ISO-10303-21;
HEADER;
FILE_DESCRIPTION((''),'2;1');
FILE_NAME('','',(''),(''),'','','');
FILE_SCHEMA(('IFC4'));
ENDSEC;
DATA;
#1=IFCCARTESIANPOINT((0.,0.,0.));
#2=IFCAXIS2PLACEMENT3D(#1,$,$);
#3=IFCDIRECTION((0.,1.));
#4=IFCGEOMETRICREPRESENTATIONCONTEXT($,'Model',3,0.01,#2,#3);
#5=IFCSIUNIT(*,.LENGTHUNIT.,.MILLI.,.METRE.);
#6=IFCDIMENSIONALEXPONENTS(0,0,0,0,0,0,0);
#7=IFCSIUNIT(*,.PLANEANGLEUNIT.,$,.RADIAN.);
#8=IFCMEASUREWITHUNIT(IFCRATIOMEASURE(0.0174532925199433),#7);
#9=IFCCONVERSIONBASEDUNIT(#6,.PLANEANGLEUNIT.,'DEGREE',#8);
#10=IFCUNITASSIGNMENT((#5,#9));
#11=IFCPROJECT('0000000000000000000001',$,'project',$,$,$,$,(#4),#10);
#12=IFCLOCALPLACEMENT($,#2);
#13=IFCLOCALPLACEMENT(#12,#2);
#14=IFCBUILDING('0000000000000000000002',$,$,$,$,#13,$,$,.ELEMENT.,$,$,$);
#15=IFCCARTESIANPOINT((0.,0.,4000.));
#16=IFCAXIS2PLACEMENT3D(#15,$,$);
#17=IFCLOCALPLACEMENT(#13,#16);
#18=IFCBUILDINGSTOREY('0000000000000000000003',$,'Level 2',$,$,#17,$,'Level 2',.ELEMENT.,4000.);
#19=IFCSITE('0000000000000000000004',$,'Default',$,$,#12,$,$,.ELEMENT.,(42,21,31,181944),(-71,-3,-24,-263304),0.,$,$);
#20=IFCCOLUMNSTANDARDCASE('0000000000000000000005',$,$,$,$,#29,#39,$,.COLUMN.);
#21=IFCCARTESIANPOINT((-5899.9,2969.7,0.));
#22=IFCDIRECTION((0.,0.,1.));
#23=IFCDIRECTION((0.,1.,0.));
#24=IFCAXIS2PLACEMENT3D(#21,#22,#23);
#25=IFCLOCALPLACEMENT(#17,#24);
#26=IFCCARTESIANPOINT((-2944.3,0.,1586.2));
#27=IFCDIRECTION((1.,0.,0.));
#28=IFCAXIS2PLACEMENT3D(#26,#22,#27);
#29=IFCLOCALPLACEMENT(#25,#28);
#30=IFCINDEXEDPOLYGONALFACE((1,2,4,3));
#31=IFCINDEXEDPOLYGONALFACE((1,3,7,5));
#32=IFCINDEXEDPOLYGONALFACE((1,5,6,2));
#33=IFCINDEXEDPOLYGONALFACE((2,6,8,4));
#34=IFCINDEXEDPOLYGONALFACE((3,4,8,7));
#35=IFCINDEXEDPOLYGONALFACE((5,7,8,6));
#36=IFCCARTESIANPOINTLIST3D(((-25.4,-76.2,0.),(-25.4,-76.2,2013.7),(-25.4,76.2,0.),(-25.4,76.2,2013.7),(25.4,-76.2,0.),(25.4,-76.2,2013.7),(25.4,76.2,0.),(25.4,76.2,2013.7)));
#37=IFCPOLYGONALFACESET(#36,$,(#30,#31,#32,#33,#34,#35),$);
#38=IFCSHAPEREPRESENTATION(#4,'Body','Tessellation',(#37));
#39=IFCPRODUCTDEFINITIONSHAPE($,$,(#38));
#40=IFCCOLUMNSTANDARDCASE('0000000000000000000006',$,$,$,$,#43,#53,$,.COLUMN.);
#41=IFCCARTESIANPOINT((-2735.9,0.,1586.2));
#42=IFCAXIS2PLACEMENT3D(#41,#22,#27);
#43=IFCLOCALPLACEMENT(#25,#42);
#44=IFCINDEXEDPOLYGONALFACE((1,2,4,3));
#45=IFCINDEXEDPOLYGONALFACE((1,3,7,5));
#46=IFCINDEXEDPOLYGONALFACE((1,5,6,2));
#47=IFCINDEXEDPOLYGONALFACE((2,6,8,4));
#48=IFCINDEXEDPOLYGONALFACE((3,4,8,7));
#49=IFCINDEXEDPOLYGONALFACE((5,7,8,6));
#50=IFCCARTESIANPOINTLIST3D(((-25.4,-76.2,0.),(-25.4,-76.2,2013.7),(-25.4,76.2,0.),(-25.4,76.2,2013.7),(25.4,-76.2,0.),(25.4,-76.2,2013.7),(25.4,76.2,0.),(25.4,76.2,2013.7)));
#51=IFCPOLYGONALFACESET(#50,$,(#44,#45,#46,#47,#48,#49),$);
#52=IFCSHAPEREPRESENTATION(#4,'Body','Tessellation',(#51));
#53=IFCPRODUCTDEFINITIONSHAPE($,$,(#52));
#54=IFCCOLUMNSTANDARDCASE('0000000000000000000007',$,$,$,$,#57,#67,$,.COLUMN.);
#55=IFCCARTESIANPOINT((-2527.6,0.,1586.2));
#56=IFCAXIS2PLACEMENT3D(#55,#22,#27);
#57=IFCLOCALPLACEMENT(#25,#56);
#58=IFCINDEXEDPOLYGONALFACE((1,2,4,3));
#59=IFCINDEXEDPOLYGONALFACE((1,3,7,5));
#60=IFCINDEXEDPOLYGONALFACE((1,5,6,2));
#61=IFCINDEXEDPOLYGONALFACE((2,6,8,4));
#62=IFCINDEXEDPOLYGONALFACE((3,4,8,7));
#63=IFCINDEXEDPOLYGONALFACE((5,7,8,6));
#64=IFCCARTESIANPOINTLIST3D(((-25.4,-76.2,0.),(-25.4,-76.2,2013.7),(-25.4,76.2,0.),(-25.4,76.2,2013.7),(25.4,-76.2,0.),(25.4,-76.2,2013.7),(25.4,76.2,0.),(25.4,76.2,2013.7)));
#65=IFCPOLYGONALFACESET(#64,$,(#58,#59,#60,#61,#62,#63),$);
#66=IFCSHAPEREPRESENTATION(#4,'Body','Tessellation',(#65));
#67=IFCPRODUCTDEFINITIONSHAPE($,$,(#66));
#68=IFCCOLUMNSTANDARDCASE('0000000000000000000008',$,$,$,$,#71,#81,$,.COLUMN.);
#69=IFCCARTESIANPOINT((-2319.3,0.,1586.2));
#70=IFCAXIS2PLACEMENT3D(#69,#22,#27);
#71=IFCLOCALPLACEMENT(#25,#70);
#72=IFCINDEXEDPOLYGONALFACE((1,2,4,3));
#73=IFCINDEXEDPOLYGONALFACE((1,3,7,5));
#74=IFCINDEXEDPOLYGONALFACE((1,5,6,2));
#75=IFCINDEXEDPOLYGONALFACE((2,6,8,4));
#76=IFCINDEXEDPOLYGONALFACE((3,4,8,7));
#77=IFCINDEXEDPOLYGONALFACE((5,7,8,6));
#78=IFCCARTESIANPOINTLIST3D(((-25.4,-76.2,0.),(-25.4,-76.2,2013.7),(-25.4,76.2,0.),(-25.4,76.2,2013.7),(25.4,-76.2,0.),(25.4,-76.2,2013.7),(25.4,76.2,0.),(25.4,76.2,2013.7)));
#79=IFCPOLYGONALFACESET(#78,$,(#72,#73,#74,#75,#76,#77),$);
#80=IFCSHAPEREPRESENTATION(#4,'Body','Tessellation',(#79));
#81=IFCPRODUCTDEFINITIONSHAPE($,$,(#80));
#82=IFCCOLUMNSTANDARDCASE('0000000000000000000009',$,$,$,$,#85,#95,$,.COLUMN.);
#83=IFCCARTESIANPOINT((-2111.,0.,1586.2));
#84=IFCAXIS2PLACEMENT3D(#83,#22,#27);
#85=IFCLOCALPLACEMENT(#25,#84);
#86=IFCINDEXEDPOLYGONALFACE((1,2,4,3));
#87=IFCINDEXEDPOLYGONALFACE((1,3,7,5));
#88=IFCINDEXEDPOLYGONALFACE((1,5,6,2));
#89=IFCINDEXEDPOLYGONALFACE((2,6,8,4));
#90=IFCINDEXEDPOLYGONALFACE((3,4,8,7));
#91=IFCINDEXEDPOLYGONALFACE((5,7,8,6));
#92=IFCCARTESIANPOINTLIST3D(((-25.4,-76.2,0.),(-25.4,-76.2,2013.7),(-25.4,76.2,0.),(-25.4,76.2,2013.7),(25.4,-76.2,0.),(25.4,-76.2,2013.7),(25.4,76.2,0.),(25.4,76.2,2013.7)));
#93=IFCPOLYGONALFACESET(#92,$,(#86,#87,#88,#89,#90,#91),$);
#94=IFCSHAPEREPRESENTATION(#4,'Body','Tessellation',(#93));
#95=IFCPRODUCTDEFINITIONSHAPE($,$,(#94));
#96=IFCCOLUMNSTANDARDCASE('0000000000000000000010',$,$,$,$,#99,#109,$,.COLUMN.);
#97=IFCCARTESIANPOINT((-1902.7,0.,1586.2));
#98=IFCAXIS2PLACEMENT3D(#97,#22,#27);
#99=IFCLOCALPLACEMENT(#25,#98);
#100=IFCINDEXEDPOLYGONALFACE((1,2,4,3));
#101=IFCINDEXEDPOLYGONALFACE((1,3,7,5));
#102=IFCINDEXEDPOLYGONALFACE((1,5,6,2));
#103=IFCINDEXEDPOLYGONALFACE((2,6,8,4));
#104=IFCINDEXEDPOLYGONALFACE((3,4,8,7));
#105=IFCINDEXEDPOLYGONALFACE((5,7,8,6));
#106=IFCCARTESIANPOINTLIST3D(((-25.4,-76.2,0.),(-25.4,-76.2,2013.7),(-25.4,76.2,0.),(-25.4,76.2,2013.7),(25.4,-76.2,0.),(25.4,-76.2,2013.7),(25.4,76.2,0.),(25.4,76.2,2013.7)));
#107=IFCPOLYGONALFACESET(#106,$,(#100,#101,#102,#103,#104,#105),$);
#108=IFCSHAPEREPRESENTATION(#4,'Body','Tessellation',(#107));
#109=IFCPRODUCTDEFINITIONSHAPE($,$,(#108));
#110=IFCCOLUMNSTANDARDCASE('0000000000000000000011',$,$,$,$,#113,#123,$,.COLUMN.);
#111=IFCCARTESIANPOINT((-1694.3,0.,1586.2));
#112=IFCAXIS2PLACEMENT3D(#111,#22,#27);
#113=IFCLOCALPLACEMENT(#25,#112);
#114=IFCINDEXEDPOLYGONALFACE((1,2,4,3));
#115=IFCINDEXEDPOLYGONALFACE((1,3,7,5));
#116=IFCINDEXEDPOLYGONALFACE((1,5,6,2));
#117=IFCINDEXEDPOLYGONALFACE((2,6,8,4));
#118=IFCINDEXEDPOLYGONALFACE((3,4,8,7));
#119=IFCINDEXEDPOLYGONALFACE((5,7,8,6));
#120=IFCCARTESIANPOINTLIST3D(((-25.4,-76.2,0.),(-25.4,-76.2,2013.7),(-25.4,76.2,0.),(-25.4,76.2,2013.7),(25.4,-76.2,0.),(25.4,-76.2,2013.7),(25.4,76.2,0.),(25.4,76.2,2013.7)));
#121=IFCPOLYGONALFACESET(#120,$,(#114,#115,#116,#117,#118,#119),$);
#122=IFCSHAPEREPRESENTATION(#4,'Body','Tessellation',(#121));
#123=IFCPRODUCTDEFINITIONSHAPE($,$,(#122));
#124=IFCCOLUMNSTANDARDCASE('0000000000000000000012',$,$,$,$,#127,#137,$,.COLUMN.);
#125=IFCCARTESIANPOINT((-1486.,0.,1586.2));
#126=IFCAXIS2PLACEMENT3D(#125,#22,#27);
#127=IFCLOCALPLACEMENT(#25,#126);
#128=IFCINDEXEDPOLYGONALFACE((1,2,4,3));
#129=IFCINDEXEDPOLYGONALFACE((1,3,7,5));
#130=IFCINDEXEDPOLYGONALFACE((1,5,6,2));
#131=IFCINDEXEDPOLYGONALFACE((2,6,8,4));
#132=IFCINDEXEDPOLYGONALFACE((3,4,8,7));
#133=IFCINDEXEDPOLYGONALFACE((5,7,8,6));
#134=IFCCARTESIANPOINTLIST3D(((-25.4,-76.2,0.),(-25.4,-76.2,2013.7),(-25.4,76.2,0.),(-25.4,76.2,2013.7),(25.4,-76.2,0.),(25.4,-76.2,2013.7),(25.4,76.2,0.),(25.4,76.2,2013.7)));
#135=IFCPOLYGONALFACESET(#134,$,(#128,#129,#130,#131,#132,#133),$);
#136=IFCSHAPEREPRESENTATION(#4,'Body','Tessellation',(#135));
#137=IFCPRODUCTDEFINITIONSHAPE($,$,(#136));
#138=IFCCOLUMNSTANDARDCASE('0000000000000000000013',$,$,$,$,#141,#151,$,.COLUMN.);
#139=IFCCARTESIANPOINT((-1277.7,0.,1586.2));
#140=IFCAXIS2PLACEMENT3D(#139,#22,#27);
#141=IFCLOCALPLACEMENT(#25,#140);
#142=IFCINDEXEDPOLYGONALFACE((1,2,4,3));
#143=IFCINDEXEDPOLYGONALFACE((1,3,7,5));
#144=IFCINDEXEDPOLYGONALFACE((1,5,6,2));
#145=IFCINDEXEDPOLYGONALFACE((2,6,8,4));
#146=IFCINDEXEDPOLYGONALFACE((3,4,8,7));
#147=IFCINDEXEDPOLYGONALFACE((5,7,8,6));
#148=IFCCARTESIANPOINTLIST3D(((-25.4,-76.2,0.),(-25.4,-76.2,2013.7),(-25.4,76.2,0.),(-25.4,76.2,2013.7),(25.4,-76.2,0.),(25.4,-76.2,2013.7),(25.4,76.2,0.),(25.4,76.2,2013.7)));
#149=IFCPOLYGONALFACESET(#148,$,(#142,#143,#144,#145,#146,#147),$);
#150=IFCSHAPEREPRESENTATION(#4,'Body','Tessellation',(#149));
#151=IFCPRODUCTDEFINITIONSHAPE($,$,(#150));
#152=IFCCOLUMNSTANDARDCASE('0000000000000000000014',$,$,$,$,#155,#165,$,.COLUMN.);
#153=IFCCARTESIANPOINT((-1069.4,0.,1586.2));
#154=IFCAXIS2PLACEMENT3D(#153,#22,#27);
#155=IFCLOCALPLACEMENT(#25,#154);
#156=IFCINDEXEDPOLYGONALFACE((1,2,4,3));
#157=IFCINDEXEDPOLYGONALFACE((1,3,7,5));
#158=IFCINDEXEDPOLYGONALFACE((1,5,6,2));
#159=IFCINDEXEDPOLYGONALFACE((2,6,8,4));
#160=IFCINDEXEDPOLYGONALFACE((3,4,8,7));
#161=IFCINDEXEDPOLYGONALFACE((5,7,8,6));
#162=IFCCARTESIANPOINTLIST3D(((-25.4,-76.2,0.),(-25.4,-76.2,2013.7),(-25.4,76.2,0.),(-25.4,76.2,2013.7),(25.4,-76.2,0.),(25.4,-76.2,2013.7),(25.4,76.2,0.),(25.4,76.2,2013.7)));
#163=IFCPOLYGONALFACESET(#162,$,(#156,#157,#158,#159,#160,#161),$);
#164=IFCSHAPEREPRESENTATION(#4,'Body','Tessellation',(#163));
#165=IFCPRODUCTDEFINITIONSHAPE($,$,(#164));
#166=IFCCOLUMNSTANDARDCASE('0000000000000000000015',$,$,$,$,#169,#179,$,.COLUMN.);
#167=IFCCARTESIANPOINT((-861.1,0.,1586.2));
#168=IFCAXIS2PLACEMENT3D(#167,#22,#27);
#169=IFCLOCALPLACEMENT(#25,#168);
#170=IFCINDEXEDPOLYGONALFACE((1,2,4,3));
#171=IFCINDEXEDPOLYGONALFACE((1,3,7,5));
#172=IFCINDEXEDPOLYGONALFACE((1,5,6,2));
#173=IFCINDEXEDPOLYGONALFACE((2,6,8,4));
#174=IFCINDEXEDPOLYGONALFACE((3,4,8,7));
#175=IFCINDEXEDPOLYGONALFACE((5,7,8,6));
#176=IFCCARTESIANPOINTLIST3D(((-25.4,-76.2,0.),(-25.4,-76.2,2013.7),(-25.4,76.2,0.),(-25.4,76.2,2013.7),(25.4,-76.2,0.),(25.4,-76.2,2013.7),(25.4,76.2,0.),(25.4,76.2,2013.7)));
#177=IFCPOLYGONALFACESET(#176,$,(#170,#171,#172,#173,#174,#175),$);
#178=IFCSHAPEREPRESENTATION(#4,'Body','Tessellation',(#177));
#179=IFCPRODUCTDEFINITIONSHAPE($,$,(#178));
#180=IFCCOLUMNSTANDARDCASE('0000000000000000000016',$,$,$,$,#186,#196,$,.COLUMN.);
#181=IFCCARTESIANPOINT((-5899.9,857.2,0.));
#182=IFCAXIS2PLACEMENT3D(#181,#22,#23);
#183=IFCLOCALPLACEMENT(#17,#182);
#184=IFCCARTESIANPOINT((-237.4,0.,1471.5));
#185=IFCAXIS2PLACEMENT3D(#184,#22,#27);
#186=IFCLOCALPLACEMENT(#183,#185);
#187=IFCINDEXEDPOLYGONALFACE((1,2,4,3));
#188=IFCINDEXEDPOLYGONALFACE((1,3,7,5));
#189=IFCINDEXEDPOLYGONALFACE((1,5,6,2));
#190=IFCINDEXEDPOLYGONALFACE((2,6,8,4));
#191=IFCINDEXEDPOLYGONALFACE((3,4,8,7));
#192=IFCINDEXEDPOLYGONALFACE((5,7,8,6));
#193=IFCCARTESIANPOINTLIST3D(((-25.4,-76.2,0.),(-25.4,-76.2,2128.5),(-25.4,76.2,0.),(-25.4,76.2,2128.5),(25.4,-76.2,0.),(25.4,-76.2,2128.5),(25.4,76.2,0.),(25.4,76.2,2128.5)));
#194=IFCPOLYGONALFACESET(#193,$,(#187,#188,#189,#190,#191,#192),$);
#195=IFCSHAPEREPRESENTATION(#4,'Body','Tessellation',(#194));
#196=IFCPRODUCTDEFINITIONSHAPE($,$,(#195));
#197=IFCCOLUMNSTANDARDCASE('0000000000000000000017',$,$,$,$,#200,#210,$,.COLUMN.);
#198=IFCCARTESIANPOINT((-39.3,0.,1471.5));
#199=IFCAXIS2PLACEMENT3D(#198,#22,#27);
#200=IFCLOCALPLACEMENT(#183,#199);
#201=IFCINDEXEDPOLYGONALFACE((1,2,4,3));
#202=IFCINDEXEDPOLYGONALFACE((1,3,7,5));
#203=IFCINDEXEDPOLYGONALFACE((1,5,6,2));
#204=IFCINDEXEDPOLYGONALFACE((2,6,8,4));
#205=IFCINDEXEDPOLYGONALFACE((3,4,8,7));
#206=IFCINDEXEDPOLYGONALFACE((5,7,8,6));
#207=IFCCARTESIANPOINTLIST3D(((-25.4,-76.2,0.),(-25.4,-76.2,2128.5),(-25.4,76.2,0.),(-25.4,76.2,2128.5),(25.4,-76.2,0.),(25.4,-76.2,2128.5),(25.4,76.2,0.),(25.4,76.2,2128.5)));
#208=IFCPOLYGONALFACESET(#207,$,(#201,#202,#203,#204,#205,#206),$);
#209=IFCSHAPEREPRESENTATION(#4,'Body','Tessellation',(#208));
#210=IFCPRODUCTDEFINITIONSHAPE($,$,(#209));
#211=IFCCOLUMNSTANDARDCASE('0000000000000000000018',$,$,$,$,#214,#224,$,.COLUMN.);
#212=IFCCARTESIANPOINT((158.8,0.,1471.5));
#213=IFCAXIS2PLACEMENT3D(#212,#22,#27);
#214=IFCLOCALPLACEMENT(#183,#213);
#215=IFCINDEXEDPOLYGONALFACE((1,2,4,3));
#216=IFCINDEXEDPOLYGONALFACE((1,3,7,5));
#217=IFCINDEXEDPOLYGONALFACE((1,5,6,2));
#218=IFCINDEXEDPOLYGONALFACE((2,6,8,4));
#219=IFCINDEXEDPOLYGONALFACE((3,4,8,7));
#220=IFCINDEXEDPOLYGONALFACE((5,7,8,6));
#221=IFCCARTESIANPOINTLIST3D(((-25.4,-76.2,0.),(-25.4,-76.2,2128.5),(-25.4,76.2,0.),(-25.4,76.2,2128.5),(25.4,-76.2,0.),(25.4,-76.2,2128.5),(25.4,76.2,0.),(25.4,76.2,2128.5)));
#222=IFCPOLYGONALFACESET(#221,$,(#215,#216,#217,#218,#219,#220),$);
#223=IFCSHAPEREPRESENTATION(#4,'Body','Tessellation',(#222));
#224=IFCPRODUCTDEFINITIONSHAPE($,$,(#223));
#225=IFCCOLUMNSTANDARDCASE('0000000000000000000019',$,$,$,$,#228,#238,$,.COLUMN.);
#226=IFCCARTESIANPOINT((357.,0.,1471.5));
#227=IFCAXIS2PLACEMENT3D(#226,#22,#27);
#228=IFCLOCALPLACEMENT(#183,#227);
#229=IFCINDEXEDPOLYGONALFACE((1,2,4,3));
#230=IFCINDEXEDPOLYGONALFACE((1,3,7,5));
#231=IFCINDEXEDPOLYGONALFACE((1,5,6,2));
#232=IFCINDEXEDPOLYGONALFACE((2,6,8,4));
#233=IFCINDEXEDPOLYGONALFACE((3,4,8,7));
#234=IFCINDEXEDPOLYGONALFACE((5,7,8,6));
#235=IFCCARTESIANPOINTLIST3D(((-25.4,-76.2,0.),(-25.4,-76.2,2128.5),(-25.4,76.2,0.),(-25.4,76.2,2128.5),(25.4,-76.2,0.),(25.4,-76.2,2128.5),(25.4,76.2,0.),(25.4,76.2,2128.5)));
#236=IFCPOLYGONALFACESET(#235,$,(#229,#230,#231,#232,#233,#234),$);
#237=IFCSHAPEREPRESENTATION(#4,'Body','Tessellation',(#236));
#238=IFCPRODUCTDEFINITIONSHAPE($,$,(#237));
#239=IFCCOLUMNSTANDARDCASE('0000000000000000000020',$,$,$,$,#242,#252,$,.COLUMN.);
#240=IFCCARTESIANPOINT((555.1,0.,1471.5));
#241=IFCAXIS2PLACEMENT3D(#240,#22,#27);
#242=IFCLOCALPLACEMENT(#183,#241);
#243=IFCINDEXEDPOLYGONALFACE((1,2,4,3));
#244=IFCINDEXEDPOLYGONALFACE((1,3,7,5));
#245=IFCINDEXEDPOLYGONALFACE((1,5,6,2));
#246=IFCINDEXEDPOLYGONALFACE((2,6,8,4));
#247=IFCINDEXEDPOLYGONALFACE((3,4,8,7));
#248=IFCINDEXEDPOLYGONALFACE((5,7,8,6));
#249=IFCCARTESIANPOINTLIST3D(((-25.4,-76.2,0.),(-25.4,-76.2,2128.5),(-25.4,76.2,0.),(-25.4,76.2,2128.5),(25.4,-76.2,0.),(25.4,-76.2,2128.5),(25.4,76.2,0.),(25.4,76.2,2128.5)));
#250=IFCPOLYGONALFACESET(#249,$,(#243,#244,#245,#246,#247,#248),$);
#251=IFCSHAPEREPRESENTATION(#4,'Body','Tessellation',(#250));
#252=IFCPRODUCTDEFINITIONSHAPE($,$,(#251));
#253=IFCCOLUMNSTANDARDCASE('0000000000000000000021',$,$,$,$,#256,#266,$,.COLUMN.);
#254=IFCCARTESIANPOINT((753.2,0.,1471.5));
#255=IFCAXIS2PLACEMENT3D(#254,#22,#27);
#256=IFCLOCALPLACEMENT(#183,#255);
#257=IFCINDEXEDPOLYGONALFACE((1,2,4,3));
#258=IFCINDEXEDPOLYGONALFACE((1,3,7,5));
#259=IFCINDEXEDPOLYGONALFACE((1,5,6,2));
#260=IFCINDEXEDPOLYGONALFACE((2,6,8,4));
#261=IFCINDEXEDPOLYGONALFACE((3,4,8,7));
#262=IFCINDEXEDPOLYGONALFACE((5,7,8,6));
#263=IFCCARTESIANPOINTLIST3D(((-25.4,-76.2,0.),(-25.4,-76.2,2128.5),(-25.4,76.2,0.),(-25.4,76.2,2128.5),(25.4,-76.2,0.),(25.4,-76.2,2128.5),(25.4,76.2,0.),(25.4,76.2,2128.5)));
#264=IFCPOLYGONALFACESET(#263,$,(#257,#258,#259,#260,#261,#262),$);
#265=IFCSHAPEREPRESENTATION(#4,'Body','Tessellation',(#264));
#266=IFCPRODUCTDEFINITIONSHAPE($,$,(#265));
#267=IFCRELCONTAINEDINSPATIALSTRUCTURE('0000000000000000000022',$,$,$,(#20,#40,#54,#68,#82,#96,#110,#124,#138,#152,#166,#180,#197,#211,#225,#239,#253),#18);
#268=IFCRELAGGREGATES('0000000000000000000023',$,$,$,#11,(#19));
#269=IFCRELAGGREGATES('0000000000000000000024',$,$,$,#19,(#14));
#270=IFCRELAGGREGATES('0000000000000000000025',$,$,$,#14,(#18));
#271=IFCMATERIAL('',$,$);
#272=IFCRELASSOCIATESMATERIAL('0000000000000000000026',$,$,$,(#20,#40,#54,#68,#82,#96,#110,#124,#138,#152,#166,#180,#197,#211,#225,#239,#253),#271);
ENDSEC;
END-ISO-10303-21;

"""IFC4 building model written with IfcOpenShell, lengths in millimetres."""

from ifc_helpers import new_model, entity, si_unit, converted_unit, direction, frame, origin, place, context, project, spatial, rectangle, extrude, material, element, save


model = new_model("IFC4")

# Units and contexts
model_context = context("Model", 3, precision=0.01, world=origin(), true_north=direction((0.0, 1.0)))
ifc_project = project(units=[si_unit("LENGTHUNIT", "METRE", prefix="MILLI"), converted_unit("PLANEANGLEUNIT", "DEGREE", entity("IfcRatioMeasure", 0.0174532925199433), si_unit("PLANEANGLEUNIT", "RADIAN"), dimensions=[0, 0, 0, 0, 0, 0, 0])], contexts=[model_context])

# Site, building, storey
site_placement = place(None, origin())
site = spatial("IfcSite", under=ifc_project, at=site_placement, Name="Default", CompositionType="ELEMENT", RefLatitude=(42, 21, 31, 181944), RefLongitude=(-71, -3, -24, -263304), RefElevation=0.0)
building_placement = place(site_placement, origin())
building = spatial("IfcBuilding", under=site, at=building_placement, CompositionType="ELEMENT")
storey_placement = place(building_placement, frame((0.0, 0.0, 4000.0)))
storey = spatial("IfcBuildingStorey", under=building, at=storey_placement, Name="Level 2", LongName="Level 2", CompositionType="ELEMENT", Elevation=4000.0)

# Columns
ifc_material_1 = material(Name="")
placement_1 = place(storey_placement, frame((-5899.9, 2969.7, 0.0), z_axis=(0.0, 0.0, 1.0), x_axis=(0.0, 1.0, 0.0)))
for number, where, z_axis, x_axis in (
    (1, (-2944.3, 0.0, 1586.2), (0.0, 0.0, 1.0), (1.0, 0.0, 0.0)),
    (2, (-2735.9, 0.0, 1586.2), (0.0, 0.0, 1.0), (1.0, 0.0, 0.0)),
    (3, (-2527.6, 0.0, 1586.2), (0.0, 0.0, 1.0), (1.0, 0.0, 0.0)),
    (4, (-2319.3, 0.0, 1586.2), (0.0, 0.0, 1.0), (1.0, 0.0, 0.0)),
    (5, (-2111.0, 0.0, 1586.2), (0.0, 0.0, 1.0), (1.0, 0.0, 0.0)),
    (6, (-1902.7, 0.0, 1586.2), (0.0, 0.0, 1.0), (1.0, 0.0, 0.0)),
    (7, (-1694.3, 0.0, 1586.2), (0.0, 0.0, 1.0), (1.0, 0.0, 0.0)),
    (8, (-1486.0, 0.0, 1586.2), (0.0, 0.0, 1.0), (1.0, 0.0, 0.0)),
    (9, (-1277.7, 0.0, 1586.2), (0.0, 0.0, 1.0), (1.0, 0.0, 0.0)),
    (10, (-1069.4, 0.0, 1586.2), (0.0, 0.0, 1.0), (1.0, 0.0, 0.0)),
    (11, (-861.1, 0.0, 1586.2), (0.0, 0.0, 1.0), (1.0, 0.0, 0.0)),
):
    element("IfcColumnStandardCase", number, at=place(placement_1, frame(where, z_axis=z_axis, x_axis=x_axis)), inside=storey, material=ifc_material_1, PredefinedType="COLUMN", context=model_context, shape_type="SweptSolid", body=[
        extrude(rectangle(XDim=50.8, YDim=152.4), origin(), (0.0, 0.0, 1.0), 2013.8),
    ])
placement_2 = place(storey_placement, frame((-5899.9, 857.2, 0.0), z_axis=(0.0, 0.0, 1.0), x_axis=(0.0, 1.0, 0.0)))
for number, where, z_axis, x_axis in (
    (12, (-237.4, 0.0, 1471.5), (0.0, 0.0, 1.0), (1.0, 0.0, 0.0)),
    (13, (-39.3, 0.0, 1471.5), (0.0, 0.0, 1.0), (1.0, 0.0, 0.0)),
    (14, (158.8, 0.0, 1471.5), (0.0, 0.0, 1.0), (1.0, 0.0, 0.0)),
    (15, (357.0, 0.0, 1471.5), (0.0, 0.0, 1.0), (1.0, 0.0, 0.0)),
    (16, (555.1, 0.0, 1471.5), (0.0, 0.0, 1.0), (1.0, 0.0, 0.0)),
    (17, (753.2, 0.0, 1471.5), (0.0, 0.0, 1.0), (1.0, 0.0, 0.0)),
):
    element("IfcColumnStandardCase", number, at=place(placement_2, frame(where, z_axis=z_axis, x_axis=x_axis)), inside=storey, material=ifc_material_1, PredefinedType="COLUMN", context=model_context, shape_type="SweptSolid", body=[
        extrude(rectangle(XDim=50.8, YDim=152.4), origin(), (0.0, 0.0, 1.0), 2128.5),
    ])

save(model, "model.ifc")
